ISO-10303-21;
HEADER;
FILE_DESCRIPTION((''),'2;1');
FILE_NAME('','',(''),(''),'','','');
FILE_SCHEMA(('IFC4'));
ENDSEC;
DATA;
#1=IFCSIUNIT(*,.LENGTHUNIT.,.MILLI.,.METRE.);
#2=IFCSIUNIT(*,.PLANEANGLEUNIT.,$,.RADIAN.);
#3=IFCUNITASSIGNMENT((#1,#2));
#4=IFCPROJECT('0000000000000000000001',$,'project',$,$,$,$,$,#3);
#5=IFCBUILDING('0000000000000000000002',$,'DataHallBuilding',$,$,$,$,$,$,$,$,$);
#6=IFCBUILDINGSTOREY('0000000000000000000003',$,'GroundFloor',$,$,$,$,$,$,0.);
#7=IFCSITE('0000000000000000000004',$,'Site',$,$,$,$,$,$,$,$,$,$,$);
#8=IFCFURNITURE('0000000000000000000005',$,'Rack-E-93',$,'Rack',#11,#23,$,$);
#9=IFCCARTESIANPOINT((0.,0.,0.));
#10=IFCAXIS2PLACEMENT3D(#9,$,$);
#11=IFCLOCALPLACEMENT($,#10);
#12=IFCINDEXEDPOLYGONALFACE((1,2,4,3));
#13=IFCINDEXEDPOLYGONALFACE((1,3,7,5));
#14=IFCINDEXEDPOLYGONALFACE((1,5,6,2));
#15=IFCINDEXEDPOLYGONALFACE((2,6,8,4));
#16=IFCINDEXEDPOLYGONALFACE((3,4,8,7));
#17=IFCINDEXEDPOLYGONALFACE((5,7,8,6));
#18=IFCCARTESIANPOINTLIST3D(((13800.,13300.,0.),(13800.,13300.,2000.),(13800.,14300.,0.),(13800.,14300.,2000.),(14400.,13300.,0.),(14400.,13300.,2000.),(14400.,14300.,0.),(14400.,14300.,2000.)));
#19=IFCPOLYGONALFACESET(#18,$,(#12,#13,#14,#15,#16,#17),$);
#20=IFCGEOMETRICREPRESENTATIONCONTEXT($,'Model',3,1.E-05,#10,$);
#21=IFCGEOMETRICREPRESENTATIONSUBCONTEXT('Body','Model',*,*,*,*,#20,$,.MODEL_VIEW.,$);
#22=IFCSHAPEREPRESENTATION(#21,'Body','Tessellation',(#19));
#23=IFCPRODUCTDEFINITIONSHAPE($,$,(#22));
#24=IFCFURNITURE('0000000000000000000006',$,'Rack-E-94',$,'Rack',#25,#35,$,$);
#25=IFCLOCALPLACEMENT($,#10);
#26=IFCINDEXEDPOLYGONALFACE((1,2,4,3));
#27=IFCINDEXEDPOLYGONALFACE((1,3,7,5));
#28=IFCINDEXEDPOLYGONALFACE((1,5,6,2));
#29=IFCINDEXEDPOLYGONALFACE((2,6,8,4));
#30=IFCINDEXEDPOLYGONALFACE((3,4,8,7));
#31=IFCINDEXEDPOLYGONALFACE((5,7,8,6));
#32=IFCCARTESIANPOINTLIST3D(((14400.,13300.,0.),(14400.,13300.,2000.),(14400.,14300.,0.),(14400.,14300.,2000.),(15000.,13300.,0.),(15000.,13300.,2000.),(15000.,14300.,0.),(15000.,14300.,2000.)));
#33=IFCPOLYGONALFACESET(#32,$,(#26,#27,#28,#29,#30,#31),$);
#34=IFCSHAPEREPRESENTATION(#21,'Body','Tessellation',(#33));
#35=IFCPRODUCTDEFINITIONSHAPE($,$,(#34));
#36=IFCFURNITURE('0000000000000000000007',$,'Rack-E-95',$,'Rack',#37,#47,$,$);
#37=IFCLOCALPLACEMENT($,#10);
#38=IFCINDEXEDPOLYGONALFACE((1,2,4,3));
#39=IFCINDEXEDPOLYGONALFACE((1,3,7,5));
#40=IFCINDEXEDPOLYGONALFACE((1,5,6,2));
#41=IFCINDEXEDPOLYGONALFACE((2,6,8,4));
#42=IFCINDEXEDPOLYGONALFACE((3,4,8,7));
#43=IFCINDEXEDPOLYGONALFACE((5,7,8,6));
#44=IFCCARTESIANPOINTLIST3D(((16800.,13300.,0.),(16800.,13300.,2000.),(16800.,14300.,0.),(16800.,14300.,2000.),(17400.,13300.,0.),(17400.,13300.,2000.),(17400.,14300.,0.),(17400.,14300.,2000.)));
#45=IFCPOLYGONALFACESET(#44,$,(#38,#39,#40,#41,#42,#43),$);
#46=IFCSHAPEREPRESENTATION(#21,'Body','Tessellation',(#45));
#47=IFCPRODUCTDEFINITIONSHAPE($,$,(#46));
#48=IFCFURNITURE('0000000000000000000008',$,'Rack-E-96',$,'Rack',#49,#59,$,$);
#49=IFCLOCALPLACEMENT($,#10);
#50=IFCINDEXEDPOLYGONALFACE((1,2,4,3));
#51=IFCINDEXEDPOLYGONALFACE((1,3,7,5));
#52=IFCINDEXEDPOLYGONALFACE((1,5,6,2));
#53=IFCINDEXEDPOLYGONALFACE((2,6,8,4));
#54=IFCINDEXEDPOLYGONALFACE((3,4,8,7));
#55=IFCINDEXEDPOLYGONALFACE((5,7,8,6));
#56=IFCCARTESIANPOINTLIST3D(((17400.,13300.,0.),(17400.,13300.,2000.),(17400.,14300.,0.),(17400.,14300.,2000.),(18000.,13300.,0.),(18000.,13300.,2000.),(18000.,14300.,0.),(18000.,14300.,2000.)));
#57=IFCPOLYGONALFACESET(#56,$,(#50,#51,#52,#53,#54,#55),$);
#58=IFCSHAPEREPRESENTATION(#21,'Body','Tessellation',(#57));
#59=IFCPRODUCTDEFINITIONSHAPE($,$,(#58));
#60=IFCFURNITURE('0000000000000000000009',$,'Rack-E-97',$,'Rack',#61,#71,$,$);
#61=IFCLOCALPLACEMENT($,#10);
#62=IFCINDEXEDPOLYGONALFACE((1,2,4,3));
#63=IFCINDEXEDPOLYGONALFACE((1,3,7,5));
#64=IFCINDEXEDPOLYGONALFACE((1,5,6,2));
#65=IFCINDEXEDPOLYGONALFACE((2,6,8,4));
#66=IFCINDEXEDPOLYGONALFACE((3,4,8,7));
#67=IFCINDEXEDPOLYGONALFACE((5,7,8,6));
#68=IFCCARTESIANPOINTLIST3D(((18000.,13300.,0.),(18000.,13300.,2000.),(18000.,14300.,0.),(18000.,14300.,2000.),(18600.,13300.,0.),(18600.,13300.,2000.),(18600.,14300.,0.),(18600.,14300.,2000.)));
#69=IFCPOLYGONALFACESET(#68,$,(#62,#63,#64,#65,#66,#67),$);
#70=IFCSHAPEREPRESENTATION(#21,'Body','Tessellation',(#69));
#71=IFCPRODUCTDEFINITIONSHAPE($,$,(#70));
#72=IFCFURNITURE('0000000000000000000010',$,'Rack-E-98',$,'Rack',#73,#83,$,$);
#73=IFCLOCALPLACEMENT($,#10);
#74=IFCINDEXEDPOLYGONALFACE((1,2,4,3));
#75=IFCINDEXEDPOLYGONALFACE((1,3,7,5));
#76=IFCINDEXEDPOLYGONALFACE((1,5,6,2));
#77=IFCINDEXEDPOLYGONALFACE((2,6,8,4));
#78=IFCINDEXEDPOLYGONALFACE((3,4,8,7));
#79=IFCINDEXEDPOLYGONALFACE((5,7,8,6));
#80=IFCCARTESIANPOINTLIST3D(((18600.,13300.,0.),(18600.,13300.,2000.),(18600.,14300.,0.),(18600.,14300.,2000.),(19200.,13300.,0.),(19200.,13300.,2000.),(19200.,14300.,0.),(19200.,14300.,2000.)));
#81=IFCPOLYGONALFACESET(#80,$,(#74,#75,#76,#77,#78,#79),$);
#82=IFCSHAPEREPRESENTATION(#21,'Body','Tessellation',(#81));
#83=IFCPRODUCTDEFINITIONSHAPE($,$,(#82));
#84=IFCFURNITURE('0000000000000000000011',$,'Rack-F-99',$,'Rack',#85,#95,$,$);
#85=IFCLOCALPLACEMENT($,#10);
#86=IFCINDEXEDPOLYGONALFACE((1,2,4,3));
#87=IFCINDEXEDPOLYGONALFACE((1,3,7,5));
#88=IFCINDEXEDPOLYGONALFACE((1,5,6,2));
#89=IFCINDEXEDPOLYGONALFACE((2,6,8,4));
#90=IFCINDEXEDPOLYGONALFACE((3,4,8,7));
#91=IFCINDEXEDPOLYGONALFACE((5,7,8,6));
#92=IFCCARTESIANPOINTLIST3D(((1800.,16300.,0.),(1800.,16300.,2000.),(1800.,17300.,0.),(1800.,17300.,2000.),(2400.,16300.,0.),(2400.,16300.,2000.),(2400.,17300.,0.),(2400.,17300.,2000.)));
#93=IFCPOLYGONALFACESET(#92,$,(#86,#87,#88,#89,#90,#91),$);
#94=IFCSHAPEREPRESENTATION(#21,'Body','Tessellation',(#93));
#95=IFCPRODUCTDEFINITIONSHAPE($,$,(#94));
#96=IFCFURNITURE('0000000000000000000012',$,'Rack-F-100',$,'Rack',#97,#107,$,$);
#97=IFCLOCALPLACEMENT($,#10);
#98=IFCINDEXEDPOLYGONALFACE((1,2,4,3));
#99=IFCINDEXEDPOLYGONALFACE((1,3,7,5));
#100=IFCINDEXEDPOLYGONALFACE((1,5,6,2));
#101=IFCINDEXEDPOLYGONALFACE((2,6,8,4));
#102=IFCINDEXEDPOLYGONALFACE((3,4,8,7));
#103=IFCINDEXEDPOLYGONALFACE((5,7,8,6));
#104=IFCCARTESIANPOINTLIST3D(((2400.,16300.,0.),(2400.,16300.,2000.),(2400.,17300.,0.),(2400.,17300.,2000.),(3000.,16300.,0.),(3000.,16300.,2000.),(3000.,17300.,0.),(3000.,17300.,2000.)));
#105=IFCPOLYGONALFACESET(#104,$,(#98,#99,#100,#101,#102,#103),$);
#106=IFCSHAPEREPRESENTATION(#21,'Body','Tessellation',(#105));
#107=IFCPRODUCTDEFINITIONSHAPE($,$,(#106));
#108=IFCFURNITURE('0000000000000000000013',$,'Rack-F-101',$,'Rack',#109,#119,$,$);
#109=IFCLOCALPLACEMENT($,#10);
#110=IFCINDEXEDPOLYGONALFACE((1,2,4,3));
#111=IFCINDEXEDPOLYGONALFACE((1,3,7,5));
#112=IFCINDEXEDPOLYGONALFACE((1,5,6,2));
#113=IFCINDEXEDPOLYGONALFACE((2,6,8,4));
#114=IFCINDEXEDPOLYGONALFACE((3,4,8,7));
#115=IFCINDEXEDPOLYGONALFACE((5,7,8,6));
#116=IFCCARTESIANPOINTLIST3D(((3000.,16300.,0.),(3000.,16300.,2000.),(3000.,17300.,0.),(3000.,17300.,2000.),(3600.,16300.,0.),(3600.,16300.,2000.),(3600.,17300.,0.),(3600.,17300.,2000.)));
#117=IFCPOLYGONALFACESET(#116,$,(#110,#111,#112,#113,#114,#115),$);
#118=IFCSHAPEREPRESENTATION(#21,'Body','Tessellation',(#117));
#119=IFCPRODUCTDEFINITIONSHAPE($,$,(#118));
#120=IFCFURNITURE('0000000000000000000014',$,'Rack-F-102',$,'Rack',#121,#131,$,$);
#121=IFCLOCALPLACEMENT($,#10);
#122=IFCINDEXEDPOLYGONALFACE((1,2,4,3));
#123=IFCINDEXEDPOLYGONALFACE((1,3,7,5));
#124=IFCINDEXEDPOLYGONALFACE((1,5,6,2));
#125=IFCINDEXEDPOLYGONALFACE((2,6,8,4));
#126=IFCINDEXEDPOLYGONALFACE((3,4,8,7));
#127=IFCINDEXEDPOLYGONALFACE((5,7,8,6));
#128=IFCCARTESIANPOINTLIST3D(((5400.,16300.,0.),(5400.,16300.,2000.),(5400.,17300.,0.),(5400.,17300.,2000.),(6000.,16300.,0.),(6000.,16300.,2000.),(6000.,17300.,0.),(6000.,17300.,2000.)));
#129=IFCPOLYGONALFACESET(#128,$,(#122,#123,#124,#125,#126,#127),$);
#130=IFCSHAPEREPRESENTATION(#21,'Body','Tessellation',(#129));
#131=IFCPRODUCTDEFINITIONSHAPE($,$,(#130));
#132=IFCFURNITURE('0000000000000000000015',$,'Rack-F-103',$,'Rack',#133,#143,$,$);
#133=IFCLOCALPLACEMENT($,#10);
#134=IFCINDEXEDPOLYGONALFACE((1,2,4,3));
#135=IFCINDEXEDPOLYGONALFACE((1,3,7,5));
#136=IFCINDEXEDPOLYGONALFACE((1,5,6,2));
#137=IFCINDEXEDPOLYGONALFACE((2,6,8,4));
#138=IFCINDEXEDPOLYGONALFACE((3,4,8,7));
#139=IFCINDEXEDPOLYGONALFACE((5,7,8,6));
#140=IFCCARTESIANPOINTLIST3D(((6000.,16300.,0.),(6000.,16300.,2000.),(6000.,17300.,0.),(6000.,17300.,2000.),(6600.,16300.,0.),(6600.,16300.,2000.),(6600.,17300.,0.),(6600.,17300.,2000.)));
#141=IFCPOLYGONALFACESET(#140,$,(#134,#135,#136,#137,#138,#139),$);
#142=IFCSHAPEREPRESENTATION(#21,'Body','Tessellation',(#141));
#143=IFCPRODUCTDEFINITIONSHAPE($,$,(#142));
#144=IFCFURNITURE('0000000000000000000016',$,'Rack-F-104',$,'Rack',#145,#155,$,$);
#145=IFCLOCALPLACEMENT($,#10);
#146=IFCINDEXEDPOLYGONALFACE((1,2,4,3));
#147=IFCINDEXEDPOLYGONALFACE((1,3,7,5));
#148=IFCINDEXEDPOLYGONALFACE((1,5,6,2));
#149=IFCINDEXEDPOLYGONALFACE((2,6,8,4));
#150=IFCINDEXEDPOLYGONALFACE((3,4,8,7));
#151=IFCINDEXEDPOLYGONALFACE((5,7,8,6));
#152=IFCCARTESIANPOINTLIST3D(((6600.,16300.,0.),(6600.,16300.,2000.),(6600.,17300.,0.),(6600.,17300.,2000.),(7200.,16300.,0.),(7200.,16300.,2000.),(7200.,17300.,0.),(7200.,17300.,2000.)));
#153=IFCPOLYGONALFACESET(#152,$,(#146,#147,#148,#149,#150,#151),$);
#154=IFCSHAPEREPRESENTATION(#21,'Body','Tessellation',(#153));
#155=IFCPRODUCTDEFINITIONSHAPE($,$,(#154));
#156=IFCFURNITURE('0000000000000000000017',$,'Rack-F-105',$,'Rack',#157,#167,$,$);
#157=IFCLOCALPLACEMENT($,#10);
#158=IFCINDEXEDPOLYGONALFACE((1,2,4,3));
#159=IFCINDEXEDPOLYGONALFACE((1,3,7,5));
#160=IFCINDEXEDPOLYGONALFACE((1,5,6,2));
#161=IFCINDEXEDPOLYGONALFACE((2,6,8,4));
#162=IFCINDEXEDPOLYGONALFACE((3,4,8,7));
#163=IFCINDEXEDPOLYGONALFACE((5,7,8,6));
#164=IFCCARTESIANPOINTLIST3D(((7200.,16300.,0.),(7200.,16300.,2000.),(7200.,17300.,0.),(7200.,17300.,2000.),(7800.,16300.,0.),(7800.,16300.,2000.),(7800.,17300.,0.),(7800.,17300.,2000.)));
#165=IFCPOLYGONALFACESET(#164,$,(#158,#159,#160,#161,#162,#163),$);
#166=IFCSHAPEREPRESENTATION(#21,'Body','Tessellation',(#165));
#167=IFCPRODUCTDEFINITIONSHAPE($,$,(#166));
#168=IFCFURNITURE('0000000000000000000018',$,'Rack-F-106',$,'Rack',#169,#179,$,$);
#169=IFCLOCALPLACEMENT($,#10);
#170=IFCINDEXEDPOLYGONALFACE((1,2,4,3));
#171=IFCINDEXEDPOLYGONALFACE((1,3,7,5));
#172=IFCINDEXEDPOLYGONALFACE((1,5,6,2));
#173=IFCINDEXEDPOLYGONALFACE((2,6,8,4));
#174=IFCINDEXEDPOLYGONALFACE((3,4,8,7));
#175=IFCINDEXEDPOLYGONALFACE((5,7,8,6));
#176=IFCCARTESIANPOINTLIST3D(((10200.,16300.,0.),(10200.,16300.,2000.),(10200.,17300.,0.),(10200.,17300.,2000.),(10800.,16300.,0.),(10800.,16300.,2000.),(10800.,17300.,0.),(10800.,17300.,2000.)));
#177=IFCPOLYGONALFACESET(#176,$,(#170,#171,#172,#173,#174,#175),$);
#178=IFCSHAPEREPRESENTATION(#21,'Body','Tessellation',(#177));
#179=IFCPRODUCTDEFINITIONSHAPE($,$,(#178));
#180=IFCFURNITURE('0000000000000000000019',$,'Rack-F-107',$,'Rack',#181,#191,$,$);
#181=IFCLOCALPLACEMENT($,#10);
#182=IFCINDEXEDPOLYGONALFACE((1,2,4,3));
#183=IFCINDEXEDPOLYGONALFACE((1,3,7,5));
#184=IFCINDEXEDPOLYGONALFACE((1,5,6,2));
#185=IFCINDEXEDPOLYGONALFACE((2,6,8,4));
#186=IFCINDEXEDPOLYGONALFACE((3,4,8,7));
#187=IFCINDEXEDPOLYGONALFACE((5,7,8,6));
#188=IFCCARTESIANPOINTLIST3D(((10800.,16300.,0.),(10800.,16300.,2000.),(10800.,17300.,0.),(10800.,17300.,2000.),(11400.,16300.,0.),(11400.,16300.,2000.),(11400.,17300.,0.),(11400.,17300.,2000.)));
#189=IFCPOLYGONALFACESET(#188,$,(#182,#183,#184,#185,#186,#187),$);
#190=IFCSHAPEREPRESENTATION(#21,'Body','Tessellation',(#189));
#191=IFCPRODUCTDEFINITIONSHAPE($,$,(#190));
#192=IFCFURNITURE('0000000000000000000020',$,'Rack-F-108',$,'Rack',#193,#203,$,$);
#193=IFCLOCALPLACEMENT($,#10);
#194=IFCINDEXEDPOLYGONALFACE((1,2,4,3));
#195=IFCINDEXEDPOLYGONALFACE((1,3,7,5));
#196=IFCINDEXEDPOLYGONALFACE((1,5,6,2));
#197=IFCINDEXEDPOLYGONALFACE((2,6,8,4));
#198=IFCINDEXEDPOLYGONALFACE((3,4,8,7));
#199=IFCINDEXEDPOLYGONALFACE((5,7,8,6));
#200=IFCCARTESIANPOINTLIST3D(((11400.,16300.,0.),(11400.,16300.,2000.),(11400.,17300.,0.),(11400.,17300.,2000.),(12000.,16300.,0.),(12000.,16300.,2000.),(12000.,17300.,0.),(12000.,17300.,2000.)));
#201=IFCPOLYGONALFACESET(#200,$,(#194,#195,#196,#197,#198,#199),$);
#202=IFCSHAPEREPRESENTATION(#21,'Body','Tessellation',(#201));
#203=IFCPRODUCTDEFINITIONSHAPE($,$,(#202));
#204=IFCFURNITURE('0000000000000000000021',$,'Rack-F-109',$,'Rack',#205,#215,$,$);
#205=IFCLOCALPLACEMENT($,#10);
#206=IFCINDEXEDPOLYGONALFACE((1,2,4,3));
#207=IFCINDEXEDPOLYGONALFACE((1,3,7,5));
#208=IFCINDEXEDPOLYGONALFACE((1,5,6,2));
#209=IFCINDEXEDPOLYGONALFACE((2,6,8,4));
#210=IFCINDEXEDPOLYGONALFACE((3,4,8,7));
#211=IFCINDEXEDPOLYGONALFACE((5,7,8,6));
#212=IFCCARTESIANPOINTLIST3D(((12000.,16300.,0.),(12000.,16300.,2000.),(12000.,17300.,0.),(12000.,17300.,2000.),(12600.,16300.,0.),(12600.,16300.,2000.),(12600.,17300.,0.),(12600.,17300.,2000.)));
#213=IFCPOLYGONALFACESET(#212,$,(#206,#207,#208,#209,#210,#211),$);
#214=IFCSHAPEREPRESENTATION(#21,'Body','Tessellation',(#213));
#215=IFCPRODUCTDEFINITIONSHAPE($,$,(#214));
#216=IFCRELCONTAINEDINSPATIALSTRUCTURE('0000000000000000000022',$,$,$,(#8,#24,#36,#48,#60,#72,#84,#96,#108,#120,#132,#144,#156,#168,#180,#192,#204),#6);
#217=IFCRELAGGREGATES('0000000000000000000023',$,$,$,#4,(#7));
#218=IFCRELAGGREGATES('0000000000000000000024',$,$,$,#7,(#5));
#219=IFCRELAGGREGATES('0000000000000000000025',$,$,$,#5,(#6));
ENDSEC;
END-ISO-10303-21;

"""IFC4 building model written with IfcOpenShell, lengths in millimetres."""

from ifc_helpers import new_model, si_unit, frame, origin, place, context, subcontext, project, spatial, rectangle, extrude, element, save


model = new_model("IFC4")

# Units and contexts
model_context = context("Model", 3, precision=1e-05, world=origin())
body_context = subcontext(model_context, "Body", "Model", "MODEL_VIEW")
ifc_project = project(units=[si_unit("LENGTHUNIT", "METRE", prefix="MILLI"), si_unit("PLANEANGLEUNIT", "RADIAN")])

# Site, building, storey
site = spatial("IfcSite", under=ifc_project, Name="Site")
building = spatial("IfcBuilding", under=site, Name="DataHallBuilding")
storey = spatial("IfcBuildingStorey", under=building, Name="GroundFloor", Elevation=0.0)

# Furniture
furniture_1_placement = place(None, origin())
element("IfcFurniture", 1, at=furniture_1_placement, inside=storey, Name="Rack-E-93", ObjectType="Rack", context=body_context, shape_type="SweptSolid", body=[
    extrude(rectangle(XDim=600.0, YDim=1000.0), frame((14100.0, 13800.0, 0.0), z_axis=(0.0, 0.0, 1.0), x_axis=(1.0, 0.0, 0.0)), (0.0, 0.0, 1.0), 2000.0),
])
furniture_2_placement = place(None, origin())
element("IfcFurniture", 2, at=furniture_2_placement, inside=storey, Name="Rack-E-94", ObjectType="Rack", context=body_context, shape_type="SweptSolid", body=[
    extrude(rectangle(XDim=600.0, YDim=1000.0), frame((14700.0, 13800.0, 0.0), z_axis=(0.0, 0.0, 1.0), x_axis=(1.0, 0.0, 0.0)), (0.0, 0.0, 1.0), 2000.0),
])
furniture_3_placement = place(None, origin())
element("IfcFurniture", 3, at=furniture_3_placement, inside=storey, Name="Rack-E-95", ObjectType="Rack", context=body_context, shape_type="SweptSolid", body=[
    extrude(rectangle(XDim=600.0, YDim=1000.0), frame((17100.0, 13800.0, 0.0), z_axis=(0.0, 0.0, 1.0), x_axis=(1.0, 0.0, 0.0)), (0.0, 0.0, 1.0), 2000.0),
])
furniture_4_placement = place(None, origin())
element("IfcFurniture", 4, at=furniture_4_placement, inside=storey, Name="Rack-E-96", ObjectType="Rack", context=body_context, shape_type="SweptSolid", body=[
    extrude(rectangle(XDim=600.0, YDim=1000.0), frame((17700.0, 13800.0, 0.0), z_axis=(0.0, 0.0, 1.0), x_axis=(1.0, 0.0, 0.0)), (0.0, 0.0, 1.0), 2000.0),
])
furniture_5_placement = place(None, origin())
element("IfcFurniture", 5, at=furniture_5_placement, inside=storey, Name="Rack-E-97", ObjectType="Rack", context=body_context, shape_type="SweptSolid", body=[
    extrude(rectangle(XDim=600.0, YDim=1000.0), frame((18300.0, 13800.0, 0.0), z_axis=(0.0, 0.0, 1.0), x_axis=(1.0, 0.0, 0.0)), (0.0, 0.0, 1.0), 2000.0),
])
furniture_6_placement = place(None, origin())
element("IfcFurniture", 6, at=furniture_6_placement, inside=storey, Name="Rack-E-98", ObjectType="Rack", context=body_context, shape_type="SweptSolid", body=[
    extrude(rectangle(XDim=600.0, YDim=1000.0), frame((18900.0, 13800.0, 0.0), z_axis=(0.0, 0.0, 1.0), x_axis=(1.0, 0.0, 0.0)), (0.0, 0.0, 1.0), 2000.0),
])
furniture_7_placement = place(None, origin())
element("IfcFurniture", 7, at=furniture_7_placement, inside=storey, Name="Rack-F-99", ObjectType="Rack", context=body_context, shape_type="SweptSolid", body=[
    extrude(rectangle(XDim=600.0, YDim=1000.0), frame((2100.0, 16800.0, 0.0), z_axis=(0.0, 0.0, 1.0), x_axis=(1.0, 0.0, 0.0)), (0.0, 0.0, 1.0), 2000.0),
])
furniture_8_placement = place(None, origin())
element("IfcFurniture", 8, at=furniture_8_placement, inside=storey, Name="Rack-F-100", ObjectType="Rack", context=body_context, shape_type="SweptSolid", body=[
    extrude(rectangle(XDim=600.0, YDim=1000.0), frame((2700.0, 16800.0, 0.0), z_axis=(0.0, 0.0, 1.0), x_axis=(1.0, 0.0, 0.0)), (0.0, 0.0, 1.0), 2000.0),
])
furniture_9_placement = place(None, origin())
element("IfcFurniture", 9, at=furniture_9_placement, inside=storey, Name="Rack-F-101", ObjectType="Rack", context=body_context, shape_type="SweptSolid", body=[
    extrude(rectangle(XDim=600.0, YDim=1000.0), frame((3300.0, 16800.0, 0.0), z_axis=(0.0, 0.0, 1.0), x_axis=(1.0, 0.0, 0.0)), (0.0, 0.0, 1.0), 2000.0),
])
furniture_10_placement = place(None, origin())
element("IfcFurniture", 10, at=furniture_10_placement, inside=storey, Name="Rack-F-102", ObjectType="Rack", context=body_context, shape_type="SweptSolid", body=[
    extrude(rectangle(XDim=600.0, YDim=1000.0), frame((5700.0, 16800.0, 0.0), z_axis=(0.0, 0.0, 1.0), x_axis=(1.0, 0.0, 0.0)), (0.0, 0.0, 1.0), 2000.0),
])
furniture_11_placement = place(None, origin())
element("IfcFurniture", 11, at=furniture_11_placement, inside=storey, Name="Rack-F-103", ObjectType="Rack", context=body_context, shape_type="SweptSolid", body=[
    extrude(rectangle(XDim=600.0, YDim=1000.0), frame((6300.0, 16800.0, 0.0), z_axis=(0.0, 0.0, 1.0), x_axis=(1.0, 0.0, 0.0)), (0.0, 0.0, 1.0), 2000.0),
])
furniture_12_placement = place(None, origin())
element("IfcFurniture", 12, at=furniture_12_placement, inside=storey, Name="Rack-F-104", ObjectType="Rack", context=body_context, shape_type="SweptSolid", body=[
    extrude(rectangle(XDim=600.0, YDim=1000.0), frame((6900.0, 16800.0, 0.0), z_axis=(0.0, 0.0, 1.0), x_axis=(1.0, 0.0, 0.0)), (0.0, 0.0, 1.0), 2000.0),
])
furniture_13_placement = place(None, origin())
element("IfcFurniture", 13, at=furniture_13_placement, inside=storey, Name="Rack-F-105", ObjectType="Rack", context=body_context, shape_type="SweptSolid", body=[
    extrude(rectangle(XDim=600.0, YDim=1000.0), frame((7500.0, 16800.0, 0.0), z_axis=(0.0, 0.0, 1.0), x_axis=(1.0, 0.0, 0.0)), (0.0, 0.0, 1.0), 2000.0),
])
furniture_14_placement = place(None, origin())
element("IfcFurniture", 14, at=furniture_14_placement, inside=storey, Name="Rack-F-106", ObjectType="Rack", context=body_context, shape_type="SweptSolid", body=[
    extrude(rectangle(XDim=600.0, YDim=1000.0), frame((10500.0, 16800.0, 0.0), z_axis=(0.0, 0.0, 1.0), x_axis=(1.0, 0.0, 0.0)), (0.0, 0.0, 1.0), 2000.0),
])
furniture_15_placement = place(None, origin())
element("IfcFurniture", 15, at=furniture_15_placement, inside=storey, Name="Rack-F-107", ObjectType="Rack", context=body_context, shape_type="SweptSolid", body=[
    extrude(rectangle(XDim=600.0, YDim=1000.0), frame((11100.0, 16800.0, 0.0), z_axis=(0.0, 0.0, 1.0), x_axis=(1.0, 0.0, 0.0)), (0.0, 0.0, 1.0), 2000.0),
])
furniture_16_placement = place(None, origin())
element("IfcFurniture", 16, at=furniture_16_placement, inside=storey, Name="Rack-F-108", ObjectType="Rack", context=body_context, shape_type="SweptSolid", body=[
    extrude(rectangle(XDim=600.0, YDim=1000.0), frame((11700.0, 16800.0, 0.0), z_axis=(0.0, 0.0, 1.0), x_axis=(1.0, 0.0, 0.0)), (0.0, 0.0, 1.0), 2000.0),
])
furniture_17_placement = place(None, origin())
element("IfcFurniture", 17, at=furniture_17_placement, inside=storey, Name="Rack-F-109", ObjectType="Rack", context=body_context, shape_type="SweptSolid", body=[
    extrude(rectangle(XDim=600.0, YDim=1000.0), frame((12300.0, 16800.0, 0.0), z_axis=(0.0, 0.0, 1.0), x_axis=(1.0, 0.0, 0.0)), (0.0, 0.0, 1.0), 2000.0),
])

save(model, "model.ifc")
